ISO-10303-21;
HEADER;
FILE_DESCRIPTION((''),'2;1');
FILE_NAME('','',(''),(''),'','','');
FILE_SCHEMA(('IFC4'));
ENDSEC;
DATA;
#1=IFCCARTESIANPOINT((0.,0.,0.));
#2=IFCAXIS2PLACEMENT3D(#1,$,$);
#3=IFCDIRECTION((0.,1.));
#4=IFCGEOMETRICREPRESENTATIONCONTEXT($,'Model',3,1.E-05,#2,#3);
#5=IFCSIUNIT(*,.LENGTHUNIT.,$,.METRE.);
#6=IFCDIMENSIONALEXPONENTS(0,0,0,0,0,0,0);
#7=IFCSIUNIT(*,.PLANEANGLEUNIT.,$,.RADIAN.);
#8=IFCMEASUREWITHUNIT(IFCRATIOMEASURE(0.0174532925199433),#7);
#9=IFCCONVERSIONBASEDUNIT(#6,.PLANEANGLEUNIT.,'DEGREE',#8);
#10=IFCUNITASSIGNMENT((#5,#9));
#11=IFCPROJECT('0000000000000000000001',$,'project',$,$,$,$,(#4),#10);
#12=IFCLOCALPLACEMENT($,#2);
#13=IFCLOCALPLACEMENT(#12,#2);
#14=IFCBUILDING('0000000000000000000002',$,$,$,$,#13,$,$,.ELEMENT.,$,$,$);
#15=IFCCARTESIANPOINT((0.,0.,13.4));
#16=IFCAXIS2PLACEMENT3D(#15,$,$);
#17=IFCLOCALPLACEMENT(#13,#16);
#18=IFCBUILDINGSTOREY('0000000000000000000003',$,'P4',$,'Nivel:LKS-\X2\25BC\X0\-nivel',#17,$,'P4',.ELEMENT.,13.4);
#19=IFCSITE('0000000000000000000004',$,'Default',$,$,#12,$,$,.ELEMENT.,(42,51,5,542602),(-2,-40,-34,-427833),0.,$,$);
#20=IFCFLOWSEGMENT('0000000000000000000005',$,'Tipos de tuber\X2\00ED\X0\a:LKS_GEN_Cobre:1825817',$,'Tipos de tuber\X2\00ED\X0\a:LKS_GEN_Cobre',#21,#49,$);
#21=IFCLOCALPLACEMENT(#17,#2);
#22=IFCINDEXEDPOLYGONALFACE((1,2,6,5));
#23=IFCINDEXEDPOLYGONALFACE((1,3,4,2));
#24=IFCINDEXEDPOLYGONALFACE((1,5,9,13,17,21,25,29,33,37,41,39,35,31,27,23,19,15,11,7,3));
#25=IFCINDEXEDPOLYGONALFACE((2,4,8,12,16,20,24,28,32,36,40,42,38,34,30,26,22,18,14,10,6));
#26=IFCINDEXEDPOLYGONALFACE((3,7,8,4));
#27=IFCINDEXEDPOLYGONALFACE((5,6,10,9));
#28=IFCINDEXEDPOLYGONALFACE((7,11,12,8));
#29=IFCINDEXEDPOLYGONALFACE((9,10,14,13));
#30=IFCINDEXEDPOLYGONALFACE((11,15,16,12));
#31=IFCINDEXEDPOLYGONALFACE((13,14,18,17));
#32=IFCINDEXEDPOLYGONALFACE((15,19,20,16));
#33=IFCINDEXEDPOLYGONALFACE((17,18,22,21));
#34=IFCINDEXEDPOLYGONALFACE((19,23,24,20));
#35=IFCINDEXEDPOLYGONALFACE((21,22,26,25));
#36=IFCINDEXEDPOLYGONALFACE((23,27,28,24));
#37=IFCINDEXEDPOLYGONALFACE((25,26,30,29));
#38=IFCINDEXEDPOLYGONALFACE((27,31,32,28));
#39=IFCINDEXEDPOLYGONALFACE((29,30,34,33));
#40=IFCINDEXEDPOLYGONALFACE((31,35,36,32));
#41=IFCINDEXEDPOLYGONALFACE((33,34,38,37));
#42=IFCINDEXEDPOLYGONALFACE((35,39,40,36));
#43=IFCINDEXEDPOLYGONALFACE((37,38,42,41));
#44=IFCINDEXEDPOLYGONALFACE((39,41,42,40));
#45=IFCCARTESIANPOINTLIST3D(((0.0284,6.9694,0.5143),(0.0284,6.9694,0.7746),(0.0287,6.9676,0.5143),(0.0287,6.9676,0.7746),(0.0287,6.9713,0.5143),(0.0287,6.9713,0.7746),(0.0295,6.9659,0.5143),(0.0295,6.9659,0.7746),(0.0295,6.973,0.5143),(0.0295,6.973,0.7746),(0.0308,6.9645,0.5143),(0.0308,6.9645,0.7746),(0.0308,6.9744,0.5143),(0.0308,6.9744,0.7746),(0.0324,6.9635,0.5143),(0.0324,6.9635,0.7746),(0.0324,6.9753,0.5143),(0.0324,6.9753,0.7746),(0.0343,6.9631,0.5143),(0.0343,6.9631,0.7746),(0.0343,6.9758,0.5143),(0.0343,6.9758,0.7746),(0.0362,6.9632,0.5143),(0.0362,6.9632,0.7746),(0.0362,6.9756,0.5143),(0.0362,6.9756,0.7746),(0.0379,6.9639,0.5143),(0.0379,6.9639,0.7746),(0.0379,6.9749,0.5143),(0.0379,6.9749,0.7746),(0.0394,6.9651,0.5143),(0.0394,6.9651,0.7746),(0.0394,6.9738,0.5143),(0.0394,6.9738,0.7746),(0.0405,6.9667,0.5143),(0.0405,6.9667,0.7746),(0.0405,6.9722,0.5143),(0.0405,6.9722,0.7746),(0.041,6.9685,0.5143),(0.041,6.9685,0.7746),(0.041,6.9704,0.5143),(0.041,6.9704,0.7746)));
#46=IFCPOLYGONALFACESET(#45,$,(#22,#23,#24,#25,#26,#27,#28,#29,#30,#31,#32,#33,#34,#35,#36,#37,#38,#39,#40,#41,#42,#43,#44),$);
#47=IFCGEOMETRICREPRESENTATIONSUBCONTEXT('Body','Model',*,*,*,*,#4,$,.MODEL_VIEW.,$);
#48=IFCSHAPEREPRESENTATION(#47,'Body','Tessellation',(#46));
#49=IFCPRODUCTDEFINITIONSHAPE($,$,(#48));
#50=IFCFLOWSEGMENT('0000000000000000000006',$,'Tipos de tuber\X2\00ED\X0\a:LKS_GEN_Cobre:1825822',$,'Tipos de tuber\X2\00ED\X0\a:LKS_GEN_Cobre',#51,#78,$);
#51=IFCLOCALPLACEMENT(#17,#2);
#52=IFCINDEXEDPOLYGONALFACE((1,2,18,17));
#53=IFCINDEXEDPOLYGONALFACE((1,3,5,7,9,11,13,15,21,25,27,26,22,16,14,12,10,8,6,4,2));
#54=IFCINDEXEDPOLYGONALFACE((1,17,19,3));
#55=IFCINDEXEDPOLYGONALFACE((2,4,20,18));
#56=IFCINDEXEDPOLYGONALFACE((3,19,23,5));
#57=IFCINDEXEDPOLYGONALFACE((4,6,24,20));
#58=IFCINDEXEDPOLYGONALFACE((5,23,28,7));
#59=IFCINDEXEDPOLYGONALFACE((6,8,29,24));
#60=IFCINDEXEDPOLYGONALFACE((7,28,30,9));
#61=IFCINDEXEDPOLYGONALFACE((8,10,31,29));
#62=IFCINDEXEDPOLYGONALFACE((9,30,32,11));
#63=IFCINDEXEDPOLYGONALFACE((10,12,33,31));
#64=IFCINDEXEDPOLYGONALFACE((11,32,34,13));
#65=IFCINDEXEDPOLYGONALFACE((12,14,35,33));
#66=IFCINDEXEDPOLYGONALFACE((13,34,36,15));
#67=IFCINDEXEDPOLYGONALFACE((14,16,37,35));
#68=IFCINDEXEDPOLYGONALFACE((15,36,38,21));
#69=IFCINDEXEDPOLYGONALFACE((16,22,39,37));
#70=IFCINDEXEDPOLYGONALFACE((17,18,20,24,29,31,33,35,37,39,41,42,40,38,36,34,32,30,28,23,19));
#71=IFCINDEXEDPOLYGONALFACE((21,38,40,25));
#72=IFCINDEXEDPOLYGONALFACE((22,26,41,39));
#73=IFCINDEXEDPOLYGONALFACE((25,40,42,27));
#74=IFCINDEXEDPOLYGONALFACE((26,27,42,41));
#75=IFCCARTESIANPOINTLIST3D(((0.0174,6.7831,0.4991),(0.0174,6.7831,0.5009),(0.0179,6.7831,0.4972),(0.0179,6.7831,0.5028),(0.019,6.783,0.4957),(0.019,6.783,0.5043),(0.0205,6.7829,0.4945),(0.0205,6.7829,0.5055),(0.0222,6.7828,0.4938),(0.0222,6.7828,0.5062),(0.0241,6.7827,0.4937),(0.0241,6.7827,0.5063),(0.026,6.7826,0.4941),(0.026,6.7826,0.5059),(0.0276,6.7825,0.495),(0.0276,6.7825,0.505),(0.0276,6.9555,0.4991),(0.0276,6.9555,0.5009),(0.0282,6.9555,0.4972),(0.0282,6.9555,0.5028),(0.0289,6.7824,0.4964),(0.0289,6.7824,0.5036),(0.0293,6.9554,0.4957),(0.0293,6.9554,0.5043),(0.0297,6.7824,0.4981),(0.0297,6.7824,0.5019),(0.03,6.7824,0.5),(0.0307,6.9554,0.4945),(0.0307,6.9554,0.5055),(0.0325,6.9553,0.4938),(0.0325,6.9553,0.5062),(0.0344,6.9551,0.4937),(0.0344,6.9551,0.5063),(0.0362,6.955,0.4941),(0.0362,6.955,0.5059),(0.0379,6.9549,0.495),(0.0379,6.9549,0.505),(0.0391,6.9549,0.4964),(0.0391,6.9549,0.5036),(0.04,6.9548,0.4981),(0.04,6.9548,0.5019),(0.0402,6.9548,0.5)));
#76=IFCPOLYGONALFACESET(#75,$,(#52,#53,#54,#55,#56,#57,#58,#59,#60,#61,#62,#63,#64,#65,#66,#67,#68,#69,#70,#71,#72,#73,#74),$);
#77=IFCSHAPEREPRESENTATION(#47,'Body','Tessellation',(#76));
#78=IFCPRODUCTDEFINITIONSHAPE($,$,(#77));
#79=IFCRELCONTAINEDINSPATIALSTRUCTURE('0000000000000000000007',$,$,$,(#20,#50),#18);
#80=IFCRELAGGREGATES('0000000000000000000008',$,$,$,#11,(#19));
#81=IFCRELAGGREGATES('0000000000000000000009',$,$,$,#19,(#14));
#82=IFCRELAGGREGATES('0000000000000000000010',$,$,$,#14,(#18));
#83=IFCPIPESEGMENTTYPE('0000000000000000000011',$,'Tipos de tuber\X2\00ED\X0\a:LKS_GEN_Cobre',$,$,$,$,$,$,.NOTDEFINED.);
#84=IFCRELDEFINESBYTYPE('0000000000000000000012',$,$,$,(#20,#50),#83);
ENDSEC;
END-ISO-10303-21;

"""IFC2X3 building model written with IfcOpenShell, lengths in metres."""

from ifc_helpers import new_model, entity, si_unit, converted_unit, direction, frame, frame_2d, origin, place, context, subcontext, project, spatial, circle, extrude, type_object, element, save


model = new_model("IFC2X3")

# Units and contexts
model_context = context("Model", 3, precision=1e-05, world=origin(), true_north=direction((0.0, 1.0)))
body_context = subcontext(model_context, "Body", "Model", "MODEL_VIEW")
ifc_project = project(units=[si_unit("LENGTHUNIT", "METRE"), converted_unit("PLANEANGLEUNIT", "DEGREE", entity("IfcRatioMeasure", 0.0174532925199433), si_unit("PLANEANGLEUNIT", "RADIAN"), dimensions=[0, 0, 0, 0, 0, 0, 0])], contexts=[model_context])

# Site, building, storey
site_placement = place(None, origin())
site = spatial("IfcSite", under=ifc_project, at=site_placement, Name="Default", CompositionType="ELEMENT", RefLatitude=(42, 51, 5, 542602), RefLongitude=(-2, -40, -34, -427833), RefElevation=0.0)
building_placement = place(site_placement, origin())
building = spatial("IfcBuilding", under=site, at=building_placement, CompositionType="ELEMENT")
storey_placement = place(building_placement, frame((0.0, 0.0, 13.4)))
storey = spatial("IfcBuildingStorey", under=building, at=storey_placement, Name="P4", ObjectType="Nivel:LKS-▼-nivel", LongName="P4", CompositionType="ELEMENT", Elevation=13.4)

# Flow segments
pipe_segment_type = type_object("IfcPipeSegmentType", Name="Tipos de tubería:LKS_GEN_Cobre", PredefinedType="NOTDEFINED")
flow_segment_1_placement = place(storey_placement, origin())
element("IfcFlowSegment", 1, at=flow_segment_1_placement, inside=storey, type_object=pipe_segment_type, Name="Tipos de tubería:LKS_GEN_Cobre:1825817", ObjectType="Tipos de tubería:LKS_GEN_Cobre", context=body_context, shape_type="SweptSolid", body=[
    extrude(circle(Radius=0.0063, at=frame_2d((0.0, 0.0), x_axis=(1.0, 0.0))), frame((0.0348, 6.9694, 0.5143), z_axis=(0.0, 0.0, 1.0), x_axis=(-1.0, 0.0, 0.0)), (0.0, 0.0, 1.0), 0.2603),
])
flow_segment_2_placement = place(storey_placement, origin())
element("IfcFlowSegment", 2, at=flow_segment_2_placement, inside=storey, type_object=pipe_segment_type, Name="Tipos de tubería:LKS_GEN_Cobre:1825822", ObjectType="Tipos de tubería:LKS_GEN_Cobre", context=body_context, shape_type="SweptSolid", body=[
    extrude(circle(Radius=0.0063, at=frame_2d((0.0, 0.0), x_axis=(1.0, 0.0))), frame((0.0236, 6.7827, 0.5), z_axis=(0.059398, 0.998234, 0.0), x_axis=(0.998234, -0.059398, 0.0)), (0.0, 0.0, 1.0), 0.1727),
])

save(model, "model.ifc")
